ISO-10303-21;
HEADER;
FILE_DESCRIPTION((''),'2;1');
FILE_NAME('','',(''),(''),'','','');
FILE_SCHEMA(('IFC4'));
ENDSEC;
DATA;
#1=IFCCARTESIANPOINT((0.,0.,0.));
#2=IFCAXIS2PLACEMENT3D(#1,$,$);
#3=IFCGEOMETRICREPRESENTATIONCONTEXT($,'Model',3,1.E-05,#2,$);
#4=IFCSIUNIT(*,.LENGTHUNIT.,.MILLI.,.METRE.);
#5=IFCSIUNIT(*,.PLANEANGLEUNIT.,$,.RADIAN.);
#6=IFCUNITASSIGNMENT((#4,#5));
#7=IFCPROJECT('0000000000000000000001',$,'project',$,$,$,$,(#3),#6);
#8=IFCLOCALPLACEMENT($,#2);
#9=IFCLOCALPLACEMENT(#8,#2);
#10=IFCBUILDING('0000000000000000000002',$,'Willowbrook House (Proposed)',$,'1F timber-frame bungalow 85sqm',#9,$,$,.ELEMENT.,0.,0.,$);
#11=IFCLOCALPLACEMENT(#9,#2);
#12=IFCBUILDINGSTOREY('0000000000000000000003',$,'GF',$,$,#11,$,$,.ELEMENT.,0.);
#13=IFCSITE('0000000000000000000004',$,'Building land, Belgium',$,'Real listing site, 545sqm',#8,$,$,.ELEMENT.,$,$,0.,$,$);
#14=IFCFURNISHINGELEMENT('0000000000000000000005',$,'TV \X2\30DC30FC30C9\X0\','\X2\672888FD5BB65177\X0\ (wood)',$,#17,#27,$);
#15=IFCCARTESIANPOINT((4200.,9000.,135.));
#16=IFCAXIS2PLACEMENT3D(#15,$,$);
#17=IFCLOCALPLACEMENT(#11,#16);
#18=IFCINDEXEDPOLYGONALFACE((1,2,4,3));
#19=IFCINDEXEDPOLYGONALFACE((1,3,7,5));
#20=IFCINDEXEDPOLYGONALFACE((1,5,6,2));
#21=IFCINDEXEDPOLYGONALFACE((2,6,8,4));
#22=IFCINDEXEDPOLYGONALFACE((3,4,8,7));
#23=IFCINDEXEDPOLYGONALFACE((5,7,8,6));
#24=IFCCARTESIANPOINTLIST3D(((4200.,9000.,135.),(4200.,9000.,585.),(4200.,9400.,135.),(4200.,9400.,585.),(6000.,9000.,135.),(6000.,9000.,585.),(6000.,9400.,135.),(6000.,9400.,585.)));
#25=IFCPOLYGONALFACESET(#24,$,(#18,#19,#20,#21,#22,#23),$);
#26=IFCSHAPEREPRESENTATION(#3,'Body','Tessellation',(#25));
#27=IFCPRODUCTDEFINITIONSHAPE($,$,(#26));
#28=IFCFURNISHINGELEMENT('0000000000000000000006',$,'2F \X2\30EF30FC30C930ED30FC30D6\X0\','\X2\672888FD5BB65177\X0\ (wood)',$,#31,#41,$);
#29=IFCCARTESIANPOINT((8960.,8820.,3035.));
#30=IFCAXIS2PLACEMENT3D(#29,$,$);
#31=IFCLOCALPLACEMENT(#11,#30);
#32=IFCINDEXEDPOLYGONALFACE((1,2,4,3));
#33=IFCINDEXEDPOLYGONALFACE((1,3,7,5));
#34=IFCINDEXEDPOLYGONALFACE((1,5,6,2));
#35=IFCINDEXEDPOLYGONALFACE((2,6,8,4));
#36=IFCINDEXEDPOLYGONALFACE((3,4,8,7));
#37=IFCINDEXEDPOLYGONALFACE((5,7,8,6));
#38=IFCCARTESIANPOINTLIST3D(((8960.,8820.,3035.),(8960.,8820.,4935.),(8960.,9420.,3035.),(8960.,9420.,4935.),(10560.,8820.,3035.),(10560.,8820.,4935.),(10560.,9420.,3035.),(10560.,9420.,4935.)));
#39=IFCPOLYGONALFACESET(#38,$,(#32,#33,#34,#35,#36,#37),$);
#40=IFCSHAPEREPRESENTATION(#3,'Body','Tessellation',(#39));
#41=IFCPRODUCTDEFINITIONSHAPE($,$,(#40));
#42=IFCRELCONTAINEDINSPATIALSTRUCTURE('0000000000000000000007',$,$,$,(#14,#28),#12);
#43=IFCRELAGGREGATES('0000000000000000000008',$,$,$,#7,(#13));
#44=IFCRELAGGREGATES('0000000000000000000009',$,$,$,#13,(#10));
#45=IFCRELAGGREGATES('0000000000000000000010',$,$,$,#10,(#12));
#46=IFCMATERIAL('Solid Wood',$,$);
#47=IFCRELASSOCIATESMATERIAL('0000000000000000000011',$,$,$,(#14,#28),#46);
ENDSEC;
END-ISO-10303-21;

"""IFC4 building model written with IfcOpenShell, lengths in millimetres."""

from ifc_helpers import new_model, si_unit, frame, frame_2d, origin, place, context, project, spatial, rectangle, extrude, material, element, save


model = new_model("IFC4")

# Units and contexts
model_context = context("Model", 3, precision=1e-05, world=origin())
ifc_project = project(units=[si_unit("LENGTHUNIT", "METRE", prefix="MILLI"), si_unit("PLANEANGLEUNIT", "RADIAN")], contexts=[model_context])

# Site, building, storey
site_placement = place(None, origin())
site = spatial("IfcSite", under=ifc_project, at=site_placement, Name="Building land, Belgium", ObjectType="Real listing site, 545sqm", CompositionType="ELEMENT", RefElevation=0.0)
building_placement = place(site_placement, origin())
building = spatial("IfcBuilding", under=site, at=building_placement, Name="Willowbrook House (Proposed)", ObjectType="1F timber-frame bungalow 85sqm", CompositionType="ELEMENT", ElevationOfRefHeight=0.0, ElevationOfTerrain=0.0)
storey_placement = place(building_placement, origin())
storey = spatial("IfcBuildingStorey", under=building, at=storey_placement, Name="GF", CompositionType="ELEMENT", Elevation=0.0)

# Shared definitions
ifc_material_1 = material(Name="Solid Wood")

# Furnishing elements
furnishing_1_placement = place(storey_placement, frame((4200.0, 9000.0, 135.0)))
element("IfcFurnishingElement", 1, at=furnishing_1_placement, inside=storey, material=ifc_material_1, Name="TV ボード", Description="木製家具 (wood)", context=model_context, shape_type="SweptSolid", body=[
    extrude(rectangle(XDim=1800.0, YDim=400.0, at=frame_2d((900.0, 200.0))), frame((4200.0, 9000.0, 135.0)), (0.0, 0.0, 1.0), 450.0),
])
furnishing_2_placement = place(storey_placement, frame((8960.0, 8820.0, 3035.0)))
element("IfcFurnishingElement", 2, at=furnishing_2_placement, inside=storey, material=ifc_material_1, Name="2F ワードローブ", Description="木製家具 (wood)", context=model_context, shape_type="SweptSolid", body=[
    extrude(rectangle(XDim=1600.0, YDim=600.0, at=frame_2d((800.0, 300.0))), frame((8960.0, 8820.0, 3035.0)), (0.0, 0.0, 1.0), 1900.0),
])

save(model, "model.ifc")
